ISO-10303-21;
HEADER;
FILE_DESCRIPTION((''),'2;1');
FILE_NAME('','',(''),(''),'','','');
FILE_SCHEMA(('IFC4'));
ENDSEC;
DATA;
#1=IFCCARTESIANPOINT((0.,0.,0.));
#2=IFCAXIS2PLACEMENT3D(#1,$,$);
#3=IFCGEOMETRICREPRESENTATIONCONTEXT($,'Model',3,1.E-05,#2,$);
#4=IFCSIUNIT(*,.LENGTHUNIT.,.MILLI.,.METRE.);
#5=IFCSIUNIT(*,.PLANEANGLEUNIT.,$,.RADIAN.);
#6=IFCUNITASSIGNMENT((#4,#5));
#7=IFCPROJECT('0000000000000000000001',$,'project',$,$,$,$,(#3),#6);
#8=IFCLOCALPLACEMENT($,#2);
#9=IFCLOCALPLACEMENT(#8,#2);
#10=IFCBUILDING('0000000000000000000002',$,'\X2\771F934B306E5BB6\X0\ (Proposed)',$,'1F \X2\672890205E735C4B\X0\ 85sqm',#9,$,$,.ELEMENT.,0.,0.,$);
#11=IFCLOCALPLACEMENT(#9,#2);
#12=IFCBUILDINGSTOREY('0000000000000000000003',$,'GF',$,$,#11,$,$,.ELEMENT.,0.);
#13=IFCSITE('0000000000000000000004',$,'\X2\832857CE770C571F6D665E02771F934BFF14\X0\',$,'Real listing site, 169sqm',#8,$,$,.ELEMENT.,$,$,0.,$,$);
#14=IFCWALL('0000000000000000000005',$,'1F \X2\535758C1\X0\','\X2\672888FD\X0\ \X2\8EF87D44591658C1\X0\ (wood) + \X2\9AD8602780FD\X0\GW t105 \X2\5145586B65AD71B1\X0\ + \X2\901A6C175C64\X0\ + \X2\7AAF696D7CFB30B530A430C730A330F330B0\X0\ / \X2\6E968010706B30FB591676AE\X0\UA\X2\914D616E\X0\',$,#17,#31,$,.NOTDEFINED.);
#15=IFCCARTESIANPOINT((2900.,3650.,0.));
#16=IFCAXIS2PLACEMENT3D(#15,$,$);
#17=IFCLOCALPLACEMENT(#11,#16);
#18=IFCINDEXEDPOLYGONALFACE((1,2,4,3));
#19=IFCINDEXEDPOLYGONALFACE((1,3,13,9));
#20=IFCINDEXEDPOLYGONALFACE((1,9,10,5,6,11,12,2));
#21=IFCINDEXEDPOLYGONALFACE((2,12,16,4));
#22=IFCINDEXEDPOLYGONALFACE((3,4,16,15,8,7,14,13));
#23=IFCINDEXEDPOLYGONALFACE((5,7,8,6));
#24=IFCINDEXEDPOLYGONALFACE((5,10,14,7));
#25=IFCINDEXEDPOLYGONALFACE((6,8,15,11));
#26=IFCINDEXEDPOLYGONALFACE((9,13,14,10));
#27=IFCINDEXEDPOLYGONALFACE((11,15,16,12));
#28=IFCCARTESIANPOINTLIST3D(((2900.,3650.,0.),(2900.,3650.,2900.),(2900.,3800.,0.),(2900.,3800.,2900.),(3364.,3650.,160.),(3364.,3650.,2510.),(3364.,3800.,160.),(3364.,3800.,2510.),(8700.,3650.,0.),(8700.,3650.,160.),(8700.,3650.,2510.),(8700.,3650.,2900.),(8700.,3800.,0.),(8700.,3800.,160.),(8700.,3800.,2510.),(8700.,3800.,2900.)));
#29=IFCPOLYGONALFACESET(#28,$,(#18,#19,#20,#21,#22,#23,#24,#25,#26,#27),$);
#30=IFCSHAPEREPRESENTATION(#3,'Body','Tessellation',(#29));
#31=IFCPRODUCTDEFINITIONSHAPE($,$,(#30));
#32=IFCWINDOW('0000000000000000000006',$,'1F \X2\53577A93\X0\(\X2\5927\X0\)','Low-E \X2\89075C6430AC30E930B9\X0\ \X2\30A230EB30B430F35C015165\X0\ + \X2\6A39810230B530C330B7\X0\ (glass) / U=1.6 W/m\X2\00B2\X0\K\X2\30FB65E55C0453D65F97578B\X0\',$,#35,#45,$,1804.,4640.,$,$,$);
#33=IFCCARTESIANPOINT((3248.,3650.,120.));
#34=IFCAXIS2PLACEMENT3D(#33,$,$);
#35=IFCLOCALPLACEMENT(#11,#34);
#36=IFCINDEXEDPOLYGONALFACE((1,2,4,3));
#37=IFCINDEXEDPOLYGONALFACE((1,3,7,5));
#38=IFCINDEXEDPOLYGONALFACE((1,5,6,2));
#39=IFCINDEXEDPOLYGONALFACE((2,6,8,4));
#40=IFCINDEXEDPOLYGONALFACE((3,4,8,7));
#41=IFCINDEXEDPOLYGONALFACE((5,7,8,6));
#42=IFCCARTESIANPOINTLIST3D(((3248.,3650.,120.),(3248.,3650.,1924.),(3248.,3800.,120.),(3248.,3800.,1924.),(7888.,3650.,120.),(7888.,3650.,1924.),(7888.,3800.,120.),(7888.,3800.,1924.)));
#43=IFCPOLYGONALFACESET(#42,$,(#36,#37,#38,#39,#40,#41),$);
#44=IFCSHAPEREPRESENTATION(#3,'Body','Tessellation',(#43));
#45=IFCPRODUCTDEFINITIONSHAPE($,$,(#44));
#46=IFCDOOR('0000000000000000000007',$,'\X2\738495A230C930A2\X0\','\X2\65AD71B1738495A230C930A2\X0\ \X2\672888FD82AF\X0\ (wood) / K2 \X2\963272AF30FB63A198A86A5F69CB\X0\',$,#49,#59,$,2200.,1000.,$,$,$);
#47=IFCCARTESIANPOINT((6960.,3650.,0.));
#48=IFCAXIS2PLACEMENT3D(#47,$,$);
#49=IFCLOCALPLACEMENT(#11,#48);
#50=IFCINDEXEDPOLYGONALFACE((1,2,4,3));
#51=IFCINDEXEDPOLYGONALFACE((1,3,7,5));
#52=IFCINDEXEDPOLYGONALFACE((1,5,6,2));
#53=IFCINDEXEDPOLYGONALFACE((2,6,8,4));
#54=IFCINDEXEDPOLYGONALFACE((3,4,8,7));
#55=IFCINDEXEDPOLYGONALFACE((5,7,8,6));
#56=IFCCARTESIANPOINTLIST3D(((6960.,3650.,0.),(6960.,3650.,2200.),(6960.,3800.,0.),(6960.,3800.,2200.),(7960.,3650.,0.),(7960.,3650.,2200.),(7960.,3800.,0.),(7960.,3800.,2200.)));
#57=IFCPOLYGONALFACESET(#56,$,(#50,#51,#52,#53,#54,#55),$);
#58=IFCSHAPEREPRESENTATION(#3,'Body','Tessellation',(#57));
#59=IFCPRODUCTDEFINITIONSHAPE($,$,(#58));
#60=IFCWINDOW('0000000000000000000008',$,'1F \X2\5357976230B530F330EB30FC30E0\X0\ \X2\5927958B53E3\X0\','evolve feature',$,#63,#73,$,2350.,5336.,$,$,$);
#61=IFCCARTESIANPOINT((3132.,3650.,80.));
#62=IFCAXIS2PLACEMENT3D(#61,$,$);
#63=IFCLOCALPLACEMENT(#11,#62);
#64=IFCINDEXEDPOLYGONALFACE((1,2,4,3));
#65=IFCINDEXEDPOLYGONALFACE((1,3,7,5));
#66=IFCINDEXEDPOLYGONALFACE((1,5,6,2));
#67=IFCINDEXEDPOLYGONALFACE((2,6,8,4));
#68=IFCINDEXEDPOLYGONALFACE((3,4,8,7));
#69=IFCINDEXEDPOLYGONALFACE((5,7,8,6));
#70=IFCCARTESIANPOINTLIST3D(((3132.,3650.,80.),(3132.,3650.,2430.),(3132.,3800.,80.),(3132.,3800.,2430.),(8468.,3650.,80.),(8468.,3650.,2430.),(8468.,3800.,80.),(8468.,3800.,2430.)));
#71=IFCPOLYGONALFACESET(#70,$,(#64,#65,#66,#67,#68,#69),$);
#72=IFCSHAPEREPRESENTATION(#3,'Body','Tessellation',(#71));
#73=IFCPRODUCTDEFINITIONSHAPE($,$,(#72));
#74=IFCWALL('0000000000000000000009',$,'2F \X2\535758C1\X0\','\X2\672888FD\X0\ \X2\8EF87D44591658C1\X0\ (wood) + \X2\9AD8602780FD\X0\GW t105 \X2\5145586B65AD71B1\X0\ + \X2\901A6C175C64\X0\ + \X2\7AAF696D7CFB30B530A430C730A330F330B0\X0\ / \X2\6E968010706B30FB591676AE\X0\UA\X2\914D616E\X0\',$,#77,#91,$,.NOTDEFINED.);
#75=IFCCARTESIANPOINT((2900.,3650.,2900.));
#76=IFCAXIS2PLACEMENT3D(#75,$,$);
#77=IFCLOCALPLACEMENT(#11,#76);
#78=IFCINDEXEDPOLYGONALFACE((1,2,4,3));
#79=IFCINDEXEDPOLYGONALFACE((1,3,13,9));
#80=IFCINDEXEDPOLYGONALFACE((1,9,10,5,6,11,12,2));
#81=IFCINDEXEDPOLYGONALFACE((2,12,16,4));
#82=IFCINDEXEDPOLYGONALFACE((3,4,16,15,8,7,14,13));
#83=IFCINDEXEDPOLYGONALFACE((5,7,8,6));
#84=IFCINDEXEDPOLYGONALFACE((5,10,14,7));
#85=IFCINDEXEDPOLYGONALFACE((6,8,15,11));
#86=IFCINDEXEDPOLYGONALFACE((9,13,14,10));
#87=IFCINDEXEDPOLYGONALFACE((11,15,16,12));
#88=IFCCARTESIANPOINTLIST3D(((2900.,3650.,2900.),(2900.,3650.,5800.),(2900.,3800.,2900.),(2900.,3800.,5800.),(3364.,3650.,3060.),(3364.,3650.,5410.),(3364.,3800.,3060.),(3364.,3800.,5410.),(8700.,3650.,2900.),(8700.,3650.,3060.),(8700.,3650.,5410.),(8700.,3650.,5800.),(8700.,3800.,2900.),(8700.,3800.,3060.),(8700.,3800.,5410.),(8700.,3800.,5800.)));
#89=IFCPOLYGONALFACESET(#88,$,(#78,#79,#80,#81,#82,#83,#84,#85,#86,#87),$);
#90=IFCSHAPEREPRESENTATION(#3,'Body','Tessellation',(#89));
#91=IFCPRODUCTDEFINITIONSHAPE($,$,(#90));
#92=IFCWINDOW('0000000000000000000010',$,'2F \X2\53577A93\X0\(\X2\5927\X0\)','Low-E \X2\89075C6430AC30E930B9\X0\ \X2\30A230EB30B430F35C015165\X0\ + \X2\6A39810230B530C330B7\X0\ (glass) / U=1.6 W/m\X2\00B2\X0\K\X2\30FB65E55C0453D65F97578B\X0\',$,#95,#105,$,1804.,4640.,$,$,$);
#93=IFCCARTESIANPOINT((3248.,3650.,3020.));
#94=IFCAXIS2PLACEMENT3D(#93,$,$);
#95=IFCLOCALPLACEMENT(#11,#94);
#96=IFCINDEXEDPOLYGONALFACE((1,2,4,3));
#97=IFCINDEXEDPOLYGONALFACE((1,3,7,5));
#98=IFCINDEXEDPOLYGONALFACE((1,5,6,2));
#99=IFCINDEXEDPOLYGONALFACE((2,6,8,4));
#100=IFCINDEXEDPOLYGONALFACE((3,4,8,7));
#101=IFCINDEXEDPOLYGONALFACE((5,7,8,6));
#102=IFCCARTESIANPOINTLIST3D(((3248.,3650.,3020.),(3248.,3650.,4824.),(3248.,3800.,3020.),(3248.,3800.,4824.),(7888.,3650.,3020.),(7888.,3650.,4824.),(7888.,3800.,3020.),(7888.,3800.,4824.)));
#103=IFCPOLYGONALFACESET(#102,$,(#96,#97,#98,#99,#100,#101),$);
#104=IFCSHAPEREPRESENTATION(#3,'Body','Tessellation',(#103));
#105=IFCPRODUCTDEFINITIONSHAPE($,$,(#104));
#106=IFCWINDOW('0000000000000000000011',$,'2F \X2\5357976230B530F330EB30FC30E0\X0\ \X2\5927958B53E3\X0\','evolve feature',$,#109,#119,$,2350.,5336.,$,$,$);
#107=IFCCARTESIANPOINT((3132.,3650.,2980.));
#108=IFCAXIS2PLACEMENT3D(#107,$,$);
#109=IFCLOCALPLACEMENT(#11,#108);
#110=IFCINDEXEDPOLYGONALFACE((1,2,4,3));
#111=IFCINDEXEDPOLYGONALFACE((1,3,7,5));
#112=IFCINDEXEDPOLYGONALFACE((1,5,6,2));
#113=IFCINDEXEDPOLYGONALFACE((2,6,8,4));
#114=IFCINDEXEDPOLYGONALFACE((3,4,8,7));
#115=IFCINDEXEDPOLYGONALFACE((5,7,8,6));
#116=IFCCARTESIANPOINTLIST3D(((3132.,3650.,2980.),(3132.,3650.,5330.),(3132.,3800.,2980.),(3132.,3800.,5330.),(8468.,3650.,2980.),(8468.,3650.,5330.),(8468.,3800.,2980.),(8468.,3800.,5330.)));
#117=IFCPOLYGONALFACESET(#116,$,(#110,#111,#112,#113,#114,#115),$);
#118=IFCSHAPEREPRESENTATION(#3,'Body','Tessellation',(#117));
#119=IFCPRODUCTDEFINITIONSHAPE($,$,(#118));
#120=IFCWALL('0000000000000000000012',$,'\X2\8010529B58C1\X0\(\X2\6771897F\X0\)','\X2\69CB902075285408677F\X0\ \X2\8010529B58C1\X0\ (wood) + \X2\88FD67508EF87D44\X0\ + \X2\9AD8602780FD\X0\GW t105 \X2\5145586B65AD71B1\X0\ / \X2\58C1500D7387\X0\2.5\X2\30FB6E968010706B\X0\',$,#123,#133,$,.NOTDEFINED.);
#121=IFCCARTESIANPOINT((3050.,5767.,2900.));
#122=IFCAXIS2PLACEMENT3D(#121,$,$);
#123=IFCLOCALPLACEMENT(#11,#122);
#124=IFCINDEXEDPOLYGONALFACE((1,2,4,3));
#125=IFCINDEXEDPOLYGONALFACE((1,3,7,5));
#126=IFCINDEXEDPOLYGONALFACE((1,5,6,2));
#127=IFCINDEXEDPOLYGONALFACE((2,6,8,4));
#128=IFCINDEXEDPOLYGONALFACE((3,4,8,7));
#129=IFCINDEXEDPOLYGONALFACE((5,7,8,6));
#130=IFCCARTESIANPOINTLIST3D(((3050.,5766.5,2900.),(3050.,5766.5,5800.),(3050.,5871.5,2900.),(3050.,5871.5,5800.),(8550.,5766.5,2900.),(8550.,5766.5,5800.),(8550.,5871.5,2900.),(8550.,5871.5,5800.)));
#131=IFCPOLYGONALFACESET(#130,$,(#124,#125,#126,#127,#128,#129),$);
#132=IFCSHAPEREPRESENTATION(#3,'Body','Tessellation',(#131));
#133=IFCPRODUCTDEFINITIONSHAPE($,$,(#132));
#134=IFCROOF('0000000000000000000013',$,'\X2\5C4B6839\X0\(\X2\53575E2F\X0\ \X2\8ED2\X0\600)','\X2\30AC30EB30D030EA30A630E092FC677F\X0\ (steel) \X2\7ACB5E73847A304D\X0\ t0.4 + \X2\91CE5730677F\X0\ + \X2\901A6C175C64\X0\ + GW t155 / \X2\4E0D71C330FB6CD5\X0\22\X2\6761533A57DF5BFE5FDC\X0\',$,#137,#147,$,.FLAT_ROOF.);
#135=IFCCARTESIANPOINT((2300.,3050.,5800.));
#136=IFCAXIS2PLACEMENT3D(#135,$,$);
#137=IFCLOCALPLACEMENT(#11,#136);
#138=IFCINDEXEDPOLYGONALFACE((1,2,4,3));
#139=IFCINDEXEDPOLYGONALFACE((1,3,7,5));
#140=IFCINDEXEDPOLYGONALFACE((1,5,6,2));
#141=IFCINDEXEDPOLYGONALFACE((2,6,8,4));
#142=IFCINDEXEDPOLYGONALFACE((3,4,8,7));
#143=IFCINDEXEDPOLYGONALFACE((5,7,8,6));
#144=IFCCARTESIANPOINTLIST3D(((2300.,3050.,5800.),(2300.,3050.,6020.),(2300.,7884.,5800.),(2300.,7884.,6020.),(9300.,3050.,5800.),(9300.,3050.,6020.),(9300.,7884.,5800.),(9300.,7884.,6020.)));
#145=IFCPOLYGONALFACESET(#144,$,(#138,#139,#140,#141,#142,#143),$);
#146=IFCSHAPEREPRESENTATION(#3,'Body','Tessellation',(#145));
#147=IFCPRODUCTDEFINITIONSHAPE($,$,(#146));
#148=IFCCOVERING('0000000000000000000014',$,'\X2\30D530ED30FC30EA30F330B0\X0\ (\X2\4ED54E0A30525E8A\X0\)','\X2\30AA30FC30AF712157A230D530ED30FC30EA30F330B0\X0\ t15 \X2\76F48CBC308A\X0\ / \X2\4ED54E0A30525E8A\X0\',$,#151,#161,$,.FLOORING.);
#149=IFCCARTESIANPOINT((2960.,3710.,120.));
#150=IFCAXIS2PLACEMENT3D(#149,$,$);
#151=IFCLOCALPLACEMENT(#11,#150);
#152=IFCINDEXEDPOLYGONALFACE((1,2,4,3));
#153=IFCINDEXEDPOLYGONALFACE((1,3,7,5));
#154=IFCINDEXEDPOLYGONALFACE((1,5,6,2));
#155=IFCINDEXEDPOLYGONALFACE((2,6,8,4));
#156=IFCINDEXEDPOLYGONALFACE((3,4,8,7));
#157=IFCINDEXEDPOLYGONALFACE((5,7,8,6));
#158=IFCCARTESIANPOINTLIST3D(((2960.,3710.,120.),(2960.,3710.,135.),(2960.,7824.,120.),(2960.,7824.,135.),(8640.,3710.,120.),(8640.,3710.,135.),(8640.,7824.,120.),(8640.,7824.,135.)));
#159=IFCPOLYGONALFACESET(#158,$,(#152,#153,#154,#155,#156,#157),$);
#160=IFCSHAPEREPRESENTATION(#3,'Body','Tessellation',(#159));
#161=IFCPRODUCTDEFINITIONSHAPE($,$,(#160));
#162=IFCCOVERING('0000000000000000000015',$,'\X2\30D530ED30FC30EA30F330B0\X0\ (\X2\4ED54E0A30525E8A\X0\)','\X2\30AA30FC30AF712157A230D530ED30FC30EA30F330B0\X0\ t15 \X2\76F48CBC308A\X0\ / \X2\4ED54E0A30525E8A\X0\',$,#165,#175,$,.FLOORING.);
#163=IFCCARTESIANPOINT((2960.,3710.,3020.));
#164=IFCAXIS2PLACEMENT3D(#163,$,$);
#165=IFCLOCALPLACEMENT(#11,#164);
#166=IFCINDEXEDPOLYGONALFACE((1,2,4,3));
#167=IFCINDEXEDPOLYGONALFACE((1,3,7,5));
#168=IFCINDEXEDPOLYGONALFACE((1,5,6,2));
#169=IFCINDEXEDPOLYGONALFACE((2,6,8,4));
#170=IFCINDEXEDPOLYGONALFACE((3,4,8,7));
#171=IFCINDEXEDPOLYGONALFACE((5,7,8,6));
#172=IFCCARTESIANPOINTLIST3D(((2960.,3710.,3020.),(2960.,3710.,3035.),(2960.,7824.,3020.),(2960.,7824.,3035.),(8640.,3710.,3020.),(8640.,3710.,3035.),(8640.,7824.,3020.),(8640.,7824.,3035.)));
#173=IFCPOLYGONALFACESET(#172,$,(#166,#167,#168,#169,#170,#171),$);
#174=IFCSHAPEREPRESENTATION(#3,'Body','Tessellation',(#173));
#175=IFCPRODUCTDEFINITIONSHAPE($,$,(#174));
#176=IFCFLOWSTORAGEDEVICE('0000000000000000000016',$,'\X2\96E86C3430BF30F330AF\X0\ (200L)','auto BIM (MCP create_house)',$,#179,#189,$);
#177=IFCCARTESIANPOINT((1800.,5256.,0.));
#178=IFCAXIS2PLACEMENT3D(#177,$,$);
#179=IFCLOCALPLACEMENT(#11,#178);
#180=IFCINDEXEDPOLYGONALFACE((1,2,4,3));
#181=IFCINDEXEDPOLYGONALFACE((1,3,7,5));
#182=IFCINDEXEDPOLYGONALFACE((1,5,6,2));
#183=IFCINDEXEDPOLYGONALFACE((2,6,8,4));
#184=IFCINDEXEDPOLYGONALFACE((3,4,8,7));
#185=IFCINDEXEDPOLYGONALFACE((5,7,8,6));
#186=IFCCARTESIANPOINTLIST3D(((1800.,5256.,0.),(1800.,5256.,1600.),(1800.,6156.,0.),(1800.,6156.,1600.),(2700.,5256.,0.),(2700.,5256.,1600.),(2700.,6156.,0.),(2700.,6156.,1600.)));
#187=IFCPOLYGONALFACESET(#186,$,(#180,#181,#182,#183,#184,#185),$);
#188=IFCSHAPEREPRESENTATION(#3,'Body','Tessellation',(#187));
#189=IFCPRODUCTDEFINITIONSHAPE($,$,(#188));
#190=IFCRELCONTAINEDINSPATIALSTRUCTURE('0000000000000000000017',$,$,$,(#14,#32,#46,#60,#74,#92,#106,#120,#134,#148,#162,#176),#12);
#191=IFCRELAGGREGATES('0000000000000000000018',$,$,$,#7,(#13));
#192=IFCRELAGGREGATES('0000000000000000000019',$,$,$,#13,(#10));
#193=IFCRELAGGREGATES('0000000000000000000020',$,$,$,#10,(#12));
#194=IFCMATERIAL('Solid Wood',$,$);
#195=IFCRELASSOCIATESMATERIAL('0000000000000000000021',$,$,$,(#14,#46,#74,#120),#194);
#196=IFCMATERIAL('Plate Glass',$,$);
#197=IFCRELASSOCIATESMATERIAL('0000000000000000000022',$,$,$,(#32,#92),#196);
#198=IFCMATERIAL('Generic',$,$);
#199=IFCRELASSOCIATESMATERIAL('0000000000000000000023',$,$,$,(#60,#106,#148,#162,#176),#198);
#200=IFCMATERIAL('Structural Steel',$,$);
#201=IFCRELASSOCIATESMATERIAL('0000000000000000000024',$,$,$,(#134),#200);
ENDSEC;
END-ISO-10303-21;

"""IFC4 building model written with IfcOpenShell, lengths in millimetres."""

from ifc_helpers import new_model, si_unit, frame, frame_2d, origin, place, context, project, spatial, rectangle, extrude, material, element, fill, save


model = new_model("IFC4")

# Units and contexts
model_context = context("Model", 3, precision=1e-05, world=origin())
ifc_project = project(units=[si_unit("LENGTHUNIT", "METRE", prefix="MILLI"), si_unit("PLANEANGLEUNIT", "RADIAN")], contexts=[model_context])

# Site, building, storey
site_placement = place(None, origin())
site = spatial("IfcSite", under=ifc_project, at=site_placement, Name="茨城県土浦市真鍋４", ObjectType="Real listing site, 169sqm", CompositionType="ELEMENT", RefElevation=0.0)
building_placement = place(site_placement, origin())
building = spatial("IfcBuilding", under=site, at=building_placement, Name="真鍋の家 (Proposed)", ObjectType="1F 木造平屋 85sqm", CompositionType="ELEMENT", ElevationOfRefHeight=0.0, ElevationOfTerrain=0.0)
storey_placement = place(building_placement, origin())
storey = spatial("IfcBuildingStorey", under=building, at=storey_placement, Name="GF", CompositionType="ELEMENT", Elevation=0.0)

# Shared definitions
ifc_material_1 = material(Name="Solid Wood")
ifc_material_2 = material(Name="Generic")

# Wall, openings, windows, door
wall_1_placement = place(storey_placement, frame((2900.0, 3650.0, 0.0)))
wall_1 = element("IfcWall", 1, at=wall_1_placement, inside=storey, material=ifc_material_1, Name="1F 南壁", Description="木製 軸組外壁 (wood) + 高性能GW t105 充填断熱 + 通気層 + 窯業系サイディング / 準耐火・外皮UA配慮", PredefinedType="NOTDEFINED", context=model_context, shape_type="SweptSolid", body=[
    extrude(rectangle(XDim=5800.0, YDim=150.0, at=frame_2d((2900.0, 75.0))), frame((2900.0, 3650.0, 0.0)), (0.0, 0.0, 1.0), 2900.0),
])
opening_1_placement = place(storey_placement, frame((3248.0, 3650.0, 120.0)))
opening_1 = element("IfcOpeningElement", 2, at=opening_1_placement, cuts=wall_1, PredefinedType="NOTDEFINED", context=model_context, shape_type="SweptSolid", body=[
    extrude(rectangle(XDim=4640.0, YDim=150.0, at=frame_2d((2320.0, 75.0))), frame((3248.0, 3650.0, 120.0)), (0.0, 0.0, 1.0), 1804.0),
])
opening_2_placement = place(storey_placement, frame((6960.0, 3650.0, 0.0)))
opening_2 = element("IfcOpeningElement", 3, at=opening_2_placement, cuts=wall_1, PredefinedType="NOTDEFINED", context=model_context, shape_type="SweptSolid", body=[
    extrude(rectangle(XDim=1000.0, YDim=150.0, at=frame_2d((500.0, 75.0))), frame((6960.0, 3650.0, 0.0)), (0.0, 0.0, 1.0), 2200.0),
])
opening_3_placement = place(storey_placement, frame((3132.0, 3650.0, 80.0)))
opening_3 = element("IfcOpeningElement", 4, at=opening_3_placement, cuts=wall_1, PredefinedType="NOTDEFINED", context=model_context, shape_type="SweptSolid", body=[
    extrude(rectangle(XDim=5336.0, YDim=150.0, at=frame_2d((2668.0, 75.0))), frame((3132.0, 3650.0, 80.0)), (0.0, 0.0, 1.0), 2350.0),
])
ifc_material_3 = material(Name="Plate Glass")
window_1_placement = place(storey_placement, frame((3248.0, 3650.0, 120.0)))
window_1 = element("IfcWindow", 5, at=window_1_placement, inside=storey, material=ifc_material_3, Name="1F 南窓(大)", Description="Low-E 複層ガラス アルゴン封入 + 樹脂サッシ (glass) / U=1.6 W/m²K・日射取得型", OverallHeight=1804.0, OverallWidth=4640.0, context=model_context, shape_type="SweptSolid", body=[
    extrude(rectangle(XDim=4640.0, YDim=150.0, at=frame_2d((2320.0, 75.0))), frame((3248.0, 3650.0, 120.0)), (0.0, 0.0, 1.0), 1804.0),
])
fill(opening_1, window_1)
door_placement = place(storey_placement, frame((6960.0, 3650.0, 0.0)))
door = element("IfcDoor", 6, at=door_placement, inside=storey, material=ifc_material_1, Name="玄関ドア", Description="断熱玄関ドア 木製芯 (wood) / K2 防犯・採風機構", OverallHeight=2200.0, OverallWidth=1000.0, context=model_context, shape_type="SweptSolid", body=[
    extrude(rectangle(XDim=1000.0, YDim=150.0, at=frame_2d((500.0, 75.0))), frame((6960.0, 3650.0, 0.0)), (0.0, 0.0, 1.0), 2200.0),
])
fill(opening_2, door)
window_2_placement = place(storey_placement, frame((3132.0, 3650.0, 80.0)))
window_2 = element("IfcWindow", 7, at=window_2_placement, inside=storey, material=ifc_material_2, Name="1F 南面サンルーム 大開口", Description="evolve feature", OverallHeight=2350.0, OverallWidth=5336.0, context=model_context, shape_type="SweptSolid", body=[
    extrude(rectangle(XDim=5336.0, YDim=150.0, at=frame_2d((2668.0, 75.0))), frame((3132.0, 3650.0, 80.0)), (0.0, 0.0, 1.0), 2350.0),
])
fill(opening_3, window_2)

# Wall, openings, windows
wall_2_placement = place(storey_placement, frame((2900.0, 3650.0, 2900.0)))
wall_2 = element("IfcWall", 8, at=wall_2_placement, inside=storey, material=ifc_material_1, Name="2F 南壁", Description="木製 軸組外壁 (wood) + 高性能GW t105 充填断熱 + 通気層 + 窯業系サイディング / 準耐火・外皮UA配慮", PredefinedType="NOTDEFINED", context=model_context, shape_type="SweptSolid", body=[
    extrude(rectangle(XDim=5800.0, YDim=150.0, at=frame_2d((2900.0, 75.0))), frame((2900.0, 3650.0, 2900.0)), (0.0, 0.0, 1.0), 2900.0),
])
opening_4_placement = place(storey_placement, frame((3248.0, 3650.0, 3020.0)))
opening_4 = element("IfcOpeningElement", 9, at=opening_4_placement, cuts=wall_2, PredefinedType="NOTDEFINED", context=model_context, shape_type="SweptSolid", body=[
    extrude(rectangle(XDim=4640.0, YDim=150.0, at=frame_2d((2320.0, 75.0))), frame((3248.0, 3650.0, 3020.0)), (0.0, 0.0, 1.0), 1804.0),
])
opening_5_placement = place(storey_placement, frame((3132.0, 3650.0, 2980.0)))
opening_5 = element("IfcOpeningElement", 10, at=opening_5_placement, cuts=wall_2, PredefinedType="NOTDEFINED", context=model_context, shape_type="SweptSolid", body=[
    extrude(rectangle(XDim=5336.0, YDim=150.0, at=frame_2d((2668.0, 75.0))), frame((3132.0, 3650.0, 2980.0)), (0.0, 0.0, 1.0), 2350.0),
])
window_3_placement = place(storey_placement, frame((3248.0, 3650.0, 3020.0)))
window_3 = element("IfcWindow", 11, at=window_3_placement, inside=storey, material=ifc_material_3, Name="2F 南窓(大)", Description="Low-E 複層ガラス アルゴン封入 + 樹脂サッシ (glass) / U=1.6 W/m²K・日射取得型", OverallHeight=1804.0, OverallWidth=4640.0, context=model_context, shape_type="SweptSolid", body=[
    extrude(rectangle(XDim=4640.0, YDim=150.0, at=frame_2d((2320.0, 75.0))), frame((3248.0, 3650.0, 3020.0)), (0.0, 0.0, 1.0), 1804.0),
])
fill(opening_4, window_3)
window_4_placement = place(storey_placement, frame((3132.0, 3650.0, 2980.0)))
window_4 = element("IfcWindow", 12, at=window_4_placement, inside=storey, material=ifc_material_2, Name="2F 南面サンルーム 大開口", Description="evolve feature", OverallHeight=2350.0, OverallWidth=5336.0, context=model_context, shape_type="SweptSolid", body=[
    extrude(rectangle(XDim=5336.0, YDim=150.0, at=frame_2d((2668.0, 75.0))), frame((3132.0, 3650.0, 2980.0)), (0.0, 0.0, 1.0), 2350.0),
])
fill(opening_5, window_4)

# Wall
wall_3_placement = place(storey_placement, frame((3050.0, 5767.0, 2900.0)))
element("IfcWall", 13, at=wall_3_placement, inside=storey, material=ifc_material_1, Name="耐力壁(東西)", Description="構造用合板 耐力壁 (wood) + 製材軸組 + 高性能GW t105 充填断熱 / 壁倍率2.5・準耐火", PredefinedType="NOTDEFINED", context=model_context, shape_type="SweptSolid", body=[
    extrude(rectangle(XDim=5500.0, YDim=105.0, at=frame_2d((2750.0, 52.0))), frame((3050.0, 5767.0, 2900.0)), (0.0, 0.0, 1.0), 2900.0),
])

# Roof
ifc_material_4 = material(Name="Structural Steel")
for number, where, name in (
    (14, (2300.0, 3050.0, 5800.0), "屋根(南帯 軒600)"),
):
    element("IfcRoof", number, at=place(storey_placement, frame(where)), inside=storey, material=ifc_material_4, Name=name, Description="ガルバリウム鋼板 (steel) 立平葺き t0.4 + 野地板 + 通気層 + GW t155 / 不燃・法22条区域対応", PredefinedType="FLAT_ROOF", context=model_context, shape_type="SweptSolid", body=[
        extrude(rectangle(XDim=7000.0, YDim=4834.0, at=frame_2d((3500.0, 2417.0))), frame((2300.0, 3050.0, 5800.0)), (0.0, 0.0, 1.0), 220.0),
    ])

# Coverings
covering_1_placement = place(storey_placement, frame((2960.0, 3710.0, 120.0)))
element("IfcCovering", 15, at=covering_1_placement, inside=storey, material=ifc_material_2, Name="フローリング (仕上げ床)", Description="オーク無垢フローリング t15 直貼り / 仕上げ床", PredefinedType="FLOORING", context=model_context, shape_type="SweptSolid", body=[
    extrude(rectangle(XDim=5680.0, YDim=4114.0, at=frame_2d((2840.0, 2057.0))), frame((2960.0, 3710.0, 120.0)), (0.0, 0.0, 1.0), 15.0),
])
covering_2_placement = place(storey_placement, frame((2960.0, 3710.0, 3020.0)))
element("IfcCovering", 16, at=covering_2_placement, inside=storey, material=ifc_material_2, Name="フローリング (仕上げ床)", Description="オーク無垢フローリング t15 直貼り / 仕上げ床", PredefinedType="FLOORING", context=model_context, shape_type="SweptSolid", body=[
    extrude(rectangle(XDim=5680.0, YDim=4114.0, at=frame_2d((2840.0, 2057.0))), frame((2960.0, 3710.0, 3020.0)), (0.0, 0.0, 1.0), 15.0),
])

# Flow storage device
flow_storage_device_placement = place(storey_placement, frame((1800.0, 5256.0, 0.0)))
element("IfcFlowStorageDevice", 17, at=flow_storage_device_placement, inside=storey, material=ifc_material_2, Name="雨水タンク (200L)", Description="auto BIM (MCP create_house)", context=model_context, shape_type="SweptSolid", body=[
    extrude(rectangle(XDim=900.0, YDim=900.0, at=frame_2d((450.0, 450.0))), frame((1800.0, 5256.0, 0.0)), (0.0, 0.0, 1.0), 1600.0),
])

save(model, "model.ifc")
